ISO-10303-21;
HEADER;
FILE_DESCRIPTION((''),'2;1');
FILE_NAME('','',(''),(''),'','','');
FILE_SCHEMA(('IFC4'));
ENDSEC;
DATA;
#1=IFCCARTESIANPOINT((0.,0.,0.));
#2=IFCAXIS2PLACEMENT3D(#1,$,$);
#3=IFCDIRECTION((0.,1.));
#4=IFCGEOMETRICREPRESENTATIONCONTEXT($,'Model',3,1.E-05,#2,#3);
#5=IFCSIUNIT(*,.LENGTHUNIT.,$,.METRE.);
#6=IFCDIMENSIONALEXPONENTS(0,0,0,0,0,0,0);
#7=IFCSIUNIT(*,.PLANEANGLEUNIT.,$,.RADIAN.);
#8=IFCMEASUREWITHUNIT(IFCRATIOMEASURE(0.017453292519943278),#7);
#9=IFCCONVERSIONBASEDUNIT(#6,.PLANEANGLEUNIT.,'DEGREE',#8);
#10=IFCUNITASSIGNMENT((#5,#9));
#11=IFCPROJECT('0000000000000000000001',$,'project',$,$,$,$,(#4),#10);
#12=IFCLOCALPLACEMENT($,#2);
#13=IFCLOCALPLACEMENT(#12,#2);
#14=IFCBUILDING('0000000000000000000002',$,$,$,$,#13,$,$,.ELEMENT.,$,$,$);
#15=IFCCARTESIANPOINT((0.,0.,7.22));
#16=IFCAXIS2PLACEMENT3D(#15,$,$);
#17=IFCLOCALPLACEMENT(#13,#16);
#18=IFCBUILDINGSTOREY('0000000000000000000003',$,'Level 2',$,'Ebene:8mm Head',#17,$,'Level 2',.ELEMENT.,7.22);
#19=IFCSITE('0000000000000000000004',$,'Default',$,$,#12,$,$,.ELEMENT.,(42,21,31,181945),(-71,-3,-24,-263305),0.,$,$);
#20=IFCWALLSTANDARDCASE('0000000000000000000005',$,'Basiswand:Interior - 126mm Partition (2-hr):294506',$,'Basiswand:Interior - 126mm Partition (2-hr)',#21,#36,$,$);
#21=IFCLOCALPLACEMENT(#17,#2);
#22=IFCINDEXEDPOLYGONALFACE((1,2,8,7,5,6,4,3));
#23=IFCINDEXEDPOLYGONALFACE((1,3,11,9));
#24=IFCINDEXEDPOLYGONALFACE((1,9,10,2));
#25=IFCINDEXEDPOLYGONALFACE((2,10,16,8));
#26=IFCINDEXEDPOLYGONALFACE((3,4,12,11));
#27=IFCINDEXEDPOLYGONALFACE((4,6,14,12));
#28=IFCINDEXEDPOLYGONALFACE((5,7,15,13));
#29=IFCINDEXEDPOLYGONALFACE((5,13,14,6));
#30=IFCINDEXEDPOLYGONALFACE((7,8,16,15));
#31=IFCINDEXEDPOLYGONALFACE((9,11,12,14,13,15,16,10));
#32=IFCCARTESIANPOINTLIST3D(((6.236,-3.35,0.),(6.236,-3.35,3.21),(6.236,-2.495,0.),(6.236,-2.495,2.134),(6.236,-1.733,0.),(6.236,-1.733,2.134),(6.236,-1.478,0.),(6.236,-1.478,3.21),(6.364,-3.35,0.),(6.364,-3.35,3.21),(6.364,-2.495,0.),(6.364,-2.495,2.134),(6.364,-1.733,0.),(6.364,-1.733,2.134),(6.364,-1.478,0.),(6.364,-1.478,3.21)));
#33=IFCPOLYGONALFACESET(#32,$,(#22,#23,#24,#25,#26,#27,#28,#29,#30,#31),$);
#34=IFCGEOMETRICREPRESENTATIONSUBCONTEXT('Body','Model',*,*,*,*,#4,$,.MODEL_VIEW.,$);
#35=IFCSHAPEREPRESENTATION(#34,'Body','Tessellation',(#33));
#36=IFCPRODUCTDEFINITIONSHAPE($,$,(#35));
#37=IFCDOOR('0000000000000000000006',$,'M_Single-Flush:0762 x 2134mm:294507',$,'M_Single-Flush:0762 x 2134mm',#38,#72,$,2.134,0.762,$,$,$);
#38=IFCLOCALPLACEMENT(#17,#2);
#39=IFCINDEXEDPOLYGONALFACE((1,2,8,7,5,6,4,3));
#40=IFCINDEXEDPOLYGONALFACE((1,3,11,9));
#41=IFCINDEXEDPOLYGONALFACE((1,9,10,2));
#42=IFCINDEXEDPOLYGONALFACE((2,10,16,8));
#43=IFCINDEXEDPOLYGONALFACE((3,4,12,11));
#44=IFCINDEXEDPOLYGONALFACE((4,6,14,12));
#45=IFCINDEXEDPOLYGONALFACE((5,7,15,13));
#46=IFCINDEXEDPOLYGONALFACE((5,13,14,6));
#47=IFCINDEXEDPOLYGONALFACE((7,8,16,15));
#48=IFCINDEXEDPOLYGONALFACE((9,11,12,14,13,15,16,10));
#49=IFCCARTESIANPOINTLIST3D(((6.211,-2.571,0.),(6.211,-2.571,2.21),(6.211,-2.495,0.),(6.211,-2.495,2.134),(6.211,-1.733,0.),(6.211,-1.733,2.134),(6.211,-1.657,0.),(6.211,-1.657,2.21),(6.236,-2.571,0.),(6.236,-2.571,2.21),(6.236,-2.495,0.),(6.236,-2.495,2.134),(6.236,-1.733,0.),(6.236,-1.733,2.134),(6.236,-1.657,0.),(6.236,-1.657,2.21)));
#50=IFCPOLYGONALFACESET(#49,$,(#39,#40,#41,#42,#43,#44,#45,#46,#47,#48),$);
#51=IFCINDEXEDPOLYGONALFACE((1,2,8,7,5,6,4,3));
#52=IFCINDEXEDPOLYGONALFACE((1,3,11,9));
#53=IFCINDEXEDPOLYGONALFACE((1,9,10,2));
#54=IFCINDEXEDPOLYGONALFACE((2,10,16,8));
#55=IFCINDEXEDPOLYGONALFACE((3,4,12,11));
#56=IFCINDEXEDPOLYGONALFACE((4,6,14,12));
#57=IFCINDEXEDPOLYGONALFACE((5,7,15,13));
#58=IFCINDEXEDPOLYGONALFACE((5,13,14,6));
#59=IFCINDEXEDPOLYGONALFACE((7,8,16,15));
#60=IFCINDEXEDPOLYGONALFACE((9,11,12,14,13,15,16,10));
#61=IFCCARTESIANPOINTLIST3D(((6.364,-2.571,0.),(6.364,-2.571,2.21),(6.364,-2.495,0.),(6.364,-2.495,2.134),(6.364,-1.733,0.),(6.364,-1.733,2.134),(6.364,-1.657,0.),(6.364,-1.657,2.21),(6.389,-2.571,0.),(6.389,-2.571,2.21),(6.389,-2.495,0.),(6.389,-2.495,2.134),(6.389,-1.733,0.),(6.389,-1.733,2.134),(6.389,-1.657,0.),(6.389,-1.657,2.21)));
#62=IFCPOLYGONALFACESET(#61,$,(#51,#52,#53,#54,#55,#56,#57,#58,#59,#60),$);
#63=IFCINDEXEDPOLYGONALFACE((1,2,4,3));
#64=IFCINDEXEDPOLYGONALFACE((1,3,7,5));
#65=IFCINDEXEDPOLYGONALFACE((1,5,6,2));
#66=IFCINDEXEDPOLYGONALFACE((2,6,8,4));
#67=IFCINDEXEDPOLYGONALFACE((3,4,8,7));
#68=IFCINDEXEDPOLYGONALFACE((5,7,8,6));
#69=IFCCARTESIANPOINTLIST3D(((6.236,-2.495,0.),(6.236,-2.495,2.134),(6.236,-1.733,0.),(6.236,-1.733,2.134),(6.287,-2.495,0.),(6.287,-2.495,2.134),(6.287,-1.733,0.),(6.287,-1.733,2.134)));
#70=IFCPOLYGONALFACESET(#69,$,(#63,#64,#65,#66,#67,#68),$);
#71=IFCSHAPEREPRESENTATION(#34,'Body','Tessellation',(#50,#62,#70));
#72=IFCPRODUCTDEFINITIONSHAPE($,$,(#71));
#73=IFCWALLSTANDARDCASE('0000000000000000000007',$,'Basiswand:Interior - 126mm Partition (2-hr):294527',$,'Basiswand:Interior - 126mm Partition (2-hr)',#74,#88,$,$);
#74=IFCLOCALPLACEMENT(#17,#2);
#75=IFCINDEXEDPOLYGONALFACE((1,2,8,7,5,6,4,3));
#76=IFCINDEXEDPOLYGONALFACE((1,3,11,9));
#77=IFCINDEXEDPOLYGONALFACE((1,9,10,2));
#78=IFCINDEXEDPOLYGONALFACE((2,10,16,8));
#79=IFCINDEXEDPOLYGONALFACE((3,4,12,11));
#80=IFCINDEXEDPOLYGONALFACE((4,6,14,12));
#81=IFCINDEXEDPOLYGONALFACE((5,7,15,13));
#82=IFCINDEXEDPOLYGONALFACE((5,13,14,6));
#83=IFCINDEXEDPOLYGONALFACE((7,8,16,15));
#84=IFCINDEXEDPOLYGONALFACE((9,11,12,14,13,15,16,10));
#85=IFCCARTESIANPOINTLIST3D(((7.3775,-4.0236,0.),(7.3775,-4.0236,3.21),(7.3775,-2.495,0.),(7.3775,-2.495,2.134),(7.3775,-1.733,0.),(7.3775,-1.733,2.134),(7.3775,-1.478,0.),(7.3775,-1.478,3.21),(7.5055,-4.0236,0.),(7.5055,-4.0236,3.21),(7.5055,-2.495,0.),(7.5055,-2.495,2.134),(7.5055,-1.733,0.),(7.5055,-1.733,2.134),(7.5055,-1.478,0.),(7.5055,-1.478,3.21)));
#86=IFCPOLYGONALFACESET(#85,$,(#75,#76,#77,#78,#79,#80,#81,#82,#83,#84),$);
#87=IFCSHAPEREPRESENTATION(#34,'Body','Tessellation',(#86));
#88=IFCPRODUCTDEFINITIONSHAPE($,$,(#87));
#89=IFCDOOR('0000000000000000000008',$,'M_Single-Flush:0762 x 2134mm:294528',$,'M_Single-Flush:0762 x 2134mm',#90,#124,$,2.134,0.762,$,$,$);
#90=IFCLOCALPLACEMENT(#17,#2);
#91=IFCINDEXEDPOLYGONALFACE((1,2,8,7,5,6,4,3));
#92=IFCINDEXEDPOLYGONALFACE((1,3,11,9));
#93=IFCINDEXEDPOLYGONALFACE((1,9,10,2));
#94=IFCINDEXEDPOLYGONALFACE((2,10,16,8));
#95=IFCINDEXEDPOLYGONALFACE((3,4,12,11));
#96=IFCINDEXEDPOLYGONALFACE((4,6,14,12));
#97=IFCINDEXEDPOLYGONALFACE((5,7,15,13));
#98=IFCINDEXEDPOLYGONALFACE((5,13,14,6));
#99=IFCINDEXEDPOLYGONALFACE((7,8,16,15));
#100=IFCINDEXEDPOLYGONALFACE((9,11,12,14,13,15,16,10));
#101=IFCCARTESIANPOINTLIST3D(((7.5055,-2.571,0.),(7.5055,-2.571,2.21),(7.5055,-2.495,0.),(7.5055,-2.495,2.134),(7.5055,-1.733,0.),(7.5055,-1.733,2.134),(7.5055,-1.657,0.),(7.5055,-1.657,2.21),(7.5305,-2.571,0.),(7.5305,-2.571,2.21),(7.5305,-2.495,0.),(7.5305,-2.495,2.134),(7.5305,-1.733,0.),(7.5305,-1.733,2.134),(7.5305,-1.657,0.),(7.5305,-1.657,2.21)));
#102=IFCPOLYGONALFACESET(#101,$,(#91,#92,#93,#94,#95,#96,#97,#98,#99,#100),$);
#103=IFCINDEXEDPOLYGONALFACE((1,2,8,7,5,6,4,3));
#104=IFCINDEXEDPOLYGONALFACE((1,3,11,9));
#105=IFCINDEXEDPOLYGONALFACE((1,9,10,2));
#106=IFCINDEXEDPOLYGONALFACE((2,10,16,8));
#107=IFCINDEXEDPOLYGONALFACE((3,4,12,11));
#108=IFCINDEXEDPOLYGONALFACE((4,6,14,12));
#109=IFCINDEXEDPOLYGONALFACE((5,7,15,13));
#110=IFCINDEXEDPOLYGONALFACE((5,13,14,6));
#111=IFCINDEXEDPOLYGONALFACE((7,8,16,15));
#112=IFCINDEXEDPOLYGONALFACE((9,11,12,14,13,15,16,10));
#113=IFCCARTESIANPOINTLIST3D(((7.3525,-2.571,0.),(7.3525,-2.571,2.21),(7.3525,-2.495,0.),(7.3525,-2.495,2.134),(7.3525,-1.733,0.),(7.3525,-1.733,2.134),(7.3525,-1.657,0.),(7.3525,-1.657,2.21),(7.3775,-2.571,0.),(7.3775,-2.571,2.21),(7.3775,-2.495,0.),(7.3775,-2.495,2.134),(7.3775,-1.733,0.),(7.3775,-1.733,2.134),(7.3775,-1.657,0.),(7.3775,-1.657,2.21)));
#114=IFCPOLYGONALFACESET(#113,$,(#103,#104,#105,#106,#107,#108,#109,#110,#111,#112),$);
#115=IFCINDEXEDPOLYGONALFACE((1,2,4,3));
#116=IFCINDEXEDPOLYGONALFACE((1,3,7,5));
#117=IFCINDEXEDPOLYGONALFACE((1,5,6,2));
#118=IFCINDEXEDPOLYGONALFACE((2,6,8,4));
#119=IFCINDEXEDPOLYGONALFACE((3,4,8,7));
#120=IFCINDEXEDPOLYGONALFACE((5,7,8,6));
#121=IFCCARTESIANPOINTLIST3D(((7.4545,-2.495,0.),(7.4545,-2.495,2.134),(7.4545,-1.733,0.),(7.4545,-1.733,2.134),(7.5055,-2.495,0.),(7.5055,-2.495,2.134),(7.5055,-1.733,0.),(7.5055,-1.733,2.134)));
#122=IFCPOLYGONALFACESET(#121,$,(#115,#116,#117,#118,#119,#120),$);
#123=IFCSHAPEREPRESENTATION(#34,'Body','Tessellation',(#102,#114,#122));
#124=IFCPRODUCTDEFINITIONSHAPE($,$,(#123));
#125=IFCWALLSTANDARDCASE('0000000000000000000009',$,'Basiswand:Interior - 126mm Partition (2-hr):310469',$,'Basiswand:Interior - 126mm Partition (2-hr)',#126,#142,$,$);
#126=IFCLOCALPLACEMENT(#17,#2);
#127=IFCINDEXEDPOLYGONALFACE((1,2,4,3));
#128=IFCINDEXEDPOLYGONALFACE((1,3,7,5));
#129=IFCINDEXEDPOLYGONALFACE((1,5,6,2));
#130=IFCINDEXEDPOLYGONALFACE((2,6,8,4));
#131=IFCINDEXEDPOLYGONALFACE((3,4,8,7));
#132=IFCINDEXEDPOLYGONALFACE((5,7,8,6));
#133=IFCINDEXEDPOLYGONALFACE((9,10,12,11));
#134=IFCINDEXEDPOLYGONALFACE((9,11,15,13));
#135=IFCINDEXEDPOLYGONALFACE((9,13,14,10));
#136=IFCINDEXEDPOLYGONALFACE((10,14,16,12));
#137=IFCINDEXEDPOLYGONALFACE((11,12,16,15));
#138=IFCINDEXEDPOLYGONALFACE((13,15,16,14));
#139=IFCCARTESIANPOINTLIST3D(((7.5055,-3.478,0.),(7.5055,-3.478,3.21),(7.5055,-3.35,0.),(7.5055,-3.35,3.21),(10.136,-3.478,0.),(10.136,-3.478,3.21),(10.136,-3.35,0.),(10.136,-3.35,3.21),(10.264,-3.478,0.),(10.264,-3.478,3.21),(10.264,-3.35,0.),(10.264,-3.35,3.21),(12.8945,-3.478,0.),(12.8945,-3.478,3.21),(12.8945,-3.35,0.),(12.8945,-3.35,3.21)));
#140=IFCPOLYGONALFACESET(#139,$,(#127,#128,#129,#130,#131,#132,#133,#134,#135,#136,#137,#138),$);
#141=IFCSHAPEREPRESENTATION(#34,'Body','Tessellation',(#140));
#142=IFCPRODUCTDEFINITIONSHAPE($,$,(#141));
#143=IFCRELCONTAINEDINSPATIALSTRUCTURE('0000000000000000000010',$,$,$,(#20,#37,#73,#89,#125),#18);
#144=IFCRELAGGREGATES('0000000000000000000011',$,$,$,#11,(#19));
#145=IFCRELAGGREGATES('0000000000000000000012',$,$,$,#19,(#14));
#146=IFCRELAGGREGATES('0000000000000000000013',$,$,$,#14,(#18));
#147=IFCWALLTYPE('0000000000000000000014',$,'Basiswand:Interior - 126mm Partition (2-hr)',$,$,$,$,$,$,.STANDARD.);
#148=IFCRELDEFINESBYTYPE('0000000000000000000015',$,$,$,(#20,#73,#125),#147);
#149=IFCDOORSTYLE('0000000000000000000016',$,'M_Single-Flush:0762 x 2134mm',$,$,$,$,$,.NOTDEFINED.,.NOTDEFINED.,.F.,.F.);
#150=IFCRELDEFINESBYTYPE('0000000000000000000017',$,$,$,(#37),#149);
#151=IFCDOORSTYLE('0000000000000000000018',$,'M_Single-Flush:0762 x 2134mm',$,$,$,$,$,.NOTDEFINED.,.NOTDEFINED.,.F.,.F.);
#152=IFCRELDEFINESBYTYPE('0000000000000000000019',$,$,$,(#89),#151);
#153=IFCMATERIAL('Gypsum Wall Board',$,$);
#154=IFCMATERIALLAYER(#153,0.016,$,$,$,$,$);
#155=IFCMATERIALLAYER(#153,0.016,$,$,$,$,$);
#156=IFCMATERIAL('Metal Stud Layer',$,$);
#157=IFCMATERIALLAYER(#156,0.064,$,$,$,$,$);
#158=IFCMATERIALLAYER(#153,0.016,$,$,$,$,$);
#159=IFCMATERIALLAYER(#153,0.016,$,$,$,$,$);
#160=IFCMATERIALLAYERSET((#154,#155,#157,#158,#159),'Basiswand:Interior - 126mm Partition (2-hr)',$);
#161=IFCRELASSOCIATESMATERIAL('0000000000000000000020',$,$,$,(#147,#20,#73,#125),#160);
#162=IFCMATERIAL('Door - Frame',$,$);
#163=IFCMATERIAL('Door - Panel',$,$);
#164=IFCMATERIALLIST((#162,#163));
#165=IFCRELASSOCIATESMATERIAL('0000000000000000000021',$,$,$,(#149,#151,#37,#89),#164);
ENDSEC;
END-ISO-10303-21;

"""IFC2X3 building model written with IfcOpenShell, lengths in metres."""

from ifc_helpers import new_model, entity, si_unit, converted_unit, direction, frame, frame_2d, origin, place, context, subcontext, project, spatial, polyline, rectangle, outline, extrude, clip, bounded_halfspace, source, transform, mapped, material, material_list, layer, layer_set, layer_usage, type_object, type_shapes, element, fill, save


model = new_model("IFC2X3")

# Units and contexts
model_context = context("Model", 3, precision=1e-05, world=origin(), true_north=direction((0.0, 1.0)))
body_context = subcontext(model_context, "Body", "Model", "MODEL_VIEW")
ifc_project = project(units=[si_unit("LENGTHUNIT", "METRE"), converted_unit("PLANEANGLEUNIT", "DEGREE", entity("IfcRatioMeasure", 0.017453292519943278), si_unit("PLANEANGLEUNIT", "RADIAN"), dimensions=[0, 0, 0, 0, 0, 0, 0])], contexts=[model_context])

# Site, building, storey
site_placement = place(None, origin())
site = spatial("IfcSite", under=ifc_project, at=site_placement, Name="Default", CompositionType="ELEMENT", RefLatitude=(42, 21, 31, 181945), RefLongitude=(-71, -3, -24, -263305), RefElevation=0.0)
building_placement = place(site_placement, origin())
building = spatial("IfcBuilding", under=site, at=building_placement, CompositionType="ELEMENT")
storey_placement = place(building_placement, frame((0.0, 0.0, 7.22)))
storey = spatial("IfcBuildingStorey", under=building, at=storey_placement, Name="Level 2", ObjectType="Ebene:8mm Head", LongName="Level 2", CompositionType="ELEMENT", Elevation=7.22)

# Shared definitions
ifc_material_1 = material(Name="Door - Frame")
ifc_material_2 = material(Name="Door - Panel")
ifc_material_list = material_list([ifc_material_1, ifc_material_2])

# Shared definitions
ifc_material_3 = material(Name="Gypsum Wall Board")
ifc_layer_1 = layer(ifc_material_3, 0.016)
ifc_layer_2 = layer(ifc_material_3, 0.016)
ifc_material_4 = material(Name="Metal Stud Layer")
ifc_layer_3 = layer(ifc_material_4, 0.064)
ifc_layer_4 = layer(ifc_material_3, 0.016)
ifc_layer_5 = layer(ifc_material_3, 0.016)
ifc_layer_set_1 = layer_set([ifc_layer_1, ifc_layer_2, ifc_layer_3, ifc_layer_4, ifc_layer_5], Name="Basiswand:Interior - 126mm Partition (2-hr)")
ifc_layer_usage_1 = layer_usage(ifc_layer_set_1, "AXIS2", "NEGATIVE", 0.064)
wall_type_1 = type_object("IfcWallType", Name="Basiswand:Interior - 126mm Partition (2-hr)", PredefinedType="STANDARD", material=ifc_layer_set_1)

# Shared definitions
door_style_1 = type_object("IfcDoorStyle", Name="M_Single-Flush:0762 x 2134mm", ConstructionType="NOTDEFINED", OperationType="NOTDEFINED", ParameterTakesPrecedence=False, Sizeable=False, material=ifc_material_list)
shared_shape_1 = source(origin(), body_context, "Body", "SweptSolid", [
    extrude(outline(polyline([(-0.457, -1.124), (0.457, -1.124), (0.457, 1.086), (0.381, 1.086), (0.381, -1.048), (-0.381, -1.048), (-0.381, 1.086), (-0.457, 1.086), (-0.457, -1.124)])), frame((0.381, 0.128, 1.086), z_axis=(0.0, 1.0, 0.0), x_axis=(1.0, 0.0, 0.0)), (0.0, 0.0, 1.0), 0.025),
    extrude(outline(polyline([(-1.124, -0.457), (1.086, -0.457), (1.086, -0.381), (-1.048, -0.381), (-1.048, 0.381), (1.086, 0.381), (1.086, 0.457), (-1.124, 0.457), (-1.124, -0.457)])), frame((0.381, -0.025, 1.086), z_axis=(0.0, 1.0, 0.0), x_axis=(0.0, 0.0, -1.0)), (0.0, 0.0, 1.0), 0.025),
    extrude(rectangle(XDim=0.051, YDim=0.762, at=frame_2d((0.0, 0.0), x_axis=(1.0, 0.0))), frame((0.381, 0.1025, 0.0), z_axis=(0.0, 0.0, 1.0), x_axis=(0.0, 1.0, 0.0)), (0.0, 0.0, 1.0), 2.134),
])
type_shapes(door_style_1, [shared_shape_1])
door_style_2 = type_object("IfcDoorStyle", Name="M_Single-Flush:0762 x 2134mm", ConstructionType="NOTDEFINED", OperationType="NOTDEFINED", ParameterTakesPrecedence=False, Sizeable=False, material=ifc_material_list)
shared_shape_2 = source(origin(), body_context, "Body", "SweptSolid", [
    extrude(outline(polyline([(-0.457, -1.124), (0.457, -1.124), (0.457, 1.086), (0.381, 1.086), (0.381, -1.048), (-0.381, -1.048), (-0.381, 1.086), (-0.457, 1.086), (-0.457, -1.124)])), frame((0.381, 0.153, 1.086), z_axis=(0.0, -1.0, 0.0), x_axis=(-1.0, 0.0, 0.0)), (0.0, 0.0, 1.0), 0.025),
    extrude(outline(polyline([(-1.124, -0.457), (1.086, -0.457), (1.086, -0.381), (-1.048, -0.381), (-1.048, 0.381), (1.086, 0.381), (1.086, 0.457), (-1.124, 0.457), (-1.124, -0.457)])), frame((0.381, 0.0, 1.086), z_axis=(0.0, -1.0, 0.0), x_axis=(0.0, 0.0, -1.0)), (0.0, 0.0, 1.0), 0.025),
    extrude(rectangle(XDim=0.762, YDim=0.051, at=frame_2d((0.0, 0.0), x_axis=(1.0, 0.0))), frame((0.381, 0.1025, 0.0)), (0.0, 0.0, 1.0), 2.134),
])
type_shapes(door_style_2, [shared_shape_2])

# Shared definitions
ifc_layer_usage_2 = layer_usage(ifc_layer_set_1, "AXIS2", "POSITIVE", -0.064)

# Walls, openings, doors
wall_1_placement = place(storey_placement, frame((6.3, -3.35, 0.0), z_axis=(0.0, 0.0, 1.0), x_axis=(0.0, 1.0, 0.0)))
wall_1 = element("IfcWallStandardCase", 1, at=wall_1_placement, inside=storey, type_object=wall_type_1, material=ifc_layer_usage_2, Name="Basiswand:Interior - 126mm Partition (2-hr):294506", ObjectType="Basiswand:Interior - 126mm Partition (2-hr)", context=body_context, shape_type="Clipping", body=[
    clip(extrude(rectangle(XDim=1.872, YDim=0.128, at=frame_2d((0.936, 0.0), x_axis=(1.0, 0.0))), origin(), (0.0, 0.0, 1.0), 3.21), bounded_halfspace(frame((0.0, -0.064, 3.21), z_axis=(0.0, 0.0, -1.0), x_axis=(1.0, 0.0, 0.0)), True, frame((0.0, -0.064, 3.21)), polyline([(0.0, 0.0), (1.872, 0.0), (1.872, 0.128), (0.0, 0.128), (0.0, 0.0)]))),
])
opening_1_placement = place(wall_1_placement, frame((0.855, -0.064, 0.0)))
opening_1 = element("IfcOpeningElement", 2, at=opening_1_placement, cuts=wall_1, ObjectType="Opening", context=body_context, shape_type="SweptSolid", body=[
    extrude(rectangle(XDim=0.762, YDim=2.134, at=frame_2d((1.067, 0.381), x_axis=(0.0, 1.0))), frame((0.0, 0.0, 0.0), z_axis=(0.0, 1.0, 0.0), x_axis=(0.0, 0.0, 1.0)), (0.0, 0.0, 1.0), 0.128),
])
door_1_placement = place(opening_1_placement, origin())
door_1 = element("IfcDoor", 3, at=door_1_placement, inside=storey, type_object=door_style_1, material=ifc_material_list, Name="M_Single-Flush:0762 x 2134mm:294507", ObjectType="M_Single-Flush:0762 x 2134mm", OverallHeight=2.134, OverallWidth=0.762, context=body_context, shape_type="MappedRepresentation", body=[
    mapped(shared_shape_1, transform((0.0, 0.0, 0.0), scale=1.0)),
])
fill(opening_1, door_1)
wall_2_placement = place(storey_placement, frame((7.4415, -4.0236, 0.0), z_axis=(0.0, 0.0, 1.0), x_axis=(0.0, 1.0, 0.0)))
wall_2 = element("IfcWallStandardCase", 4, at=wall_2_placement, inside=storey, type_object=wall_type_1, material=ifc_layer_usage_2, Name="Basiswand:Interior - 126mm Partition (2-hr):294527", ObjectType="Basiswand:Interior - 126mm Partition (2-hr)", context=body_context, shape_type="Clipping", body=[
    clip(extrude(rectangle(XDim=2.5456, YDim=0.128, at=frame_2d((1.2728, 0.0), x_axis=(1.0, 0.0))), origin(), (0.0, 0.0, 1.0), 3.21), bounded_halfspace(frame((0.0, -0.064, 3.21), z_axis=(0.0, 0.0, -1.0), x_axis=(1.0, 0.0, 0.0)), True, frame((0.0, -0.064, 3.21)), polyline([(0.0, 0.0), (0.5456, 0.0), (0.6736, 0.0), (2.5456, 0.0), (2.5456, 0.128), (0.0, 0.128), (0.0, 0.0)]))),
])
opening_2_placement = place(wall_2_placement, frame((2.2906, 0.064, 0.0)))
opening_2 = element("IfcOpeningElement", 5, at=opening_2_placement, cuts=wall_2, ObjectType="Opening", context=body_context, shape_type="SweptSolid", body=[
    extrude(rectangle(XDim=0.762, YDim=2.134, at=frame_2d((1.067, 0.381), x_axis=(0.0, -1.0))), frame((0.0, 0.0, 0.0), z_axis=(0.0, -1.0, 0.0), x_axis=(0.0, 0.0, 1.0)), (0.0, 0.0, 1.0), 0.128),
])
door_2_placement = place(opening_2_placement, frame((0.0, 0.0, 0.0), z_axis=(0.0, 0.0, 1.0), x_axis=(-1.0, 0.0, 0.0)))
door_2 = element("IfcDoor", 6, at=door_2_placement, inside=storey, type_object=door_style_2, material=ifc_material_list, Name="M_Single-Flush:0762 x 2134mm:294528", ObjectType="M_Single-Flush:0762 x 2134mm", OverallHeight=2.134, OverallWidth=0.762, context=body_context, shape_type="MappedRepresentation", body=[
    mapped(shared_shape_2, transform((0.0, 0.0, 0.0), scale=1.0)),
])
fill(opening_2, door_2)

# Wall, opening
wall_3_placement = place(storey_placement, frame((7.5055, -3.414, 0.0)))
wall_3 = element("IfcWallStandardCase", 7, at=wall_3_placement, inside=storey, type_object=wall_type_1, material=ifc_layer_usage_1, Name="Basiswand:Interior - 126mm Partition (2-hr):310469", ObjectType="Basiswand:Interior - 126mm Partition (2-hr)", context=body_context, shape_type="SweptSolid", body=[
    extrude(rectangle(XDim=5.3889, YDim=0.128, at=frame_2d((2.6945, 0.0), x_axis=(-1.0, 0.0))), origin(), (0.0, 0.0, 1.0), 3.21),
])
opening_3_placement = place(storey_placement, frame((7.5055, -3.414, 0.0)))
element("IfcOpeningElement", 8, at=opening_3_placement, cuts=wall_3, ObjectType="Opening", context=body_context, shape_type="SweptSolid", body=[
    extrude(rectangle(XDim=3.21, YDim=0.128, at=frame_2d((0.0, 0.0), x_axis=(1.0, 0.0))), frame((2.6305, 0.0, 1.605), z_axis=(1.0, 0.0, 0.0), x_axis=(0.0, 0.0, -1.0)), (0.0, 0.0, 1.0), 0.128),
])

save(model, "model.ifc")
